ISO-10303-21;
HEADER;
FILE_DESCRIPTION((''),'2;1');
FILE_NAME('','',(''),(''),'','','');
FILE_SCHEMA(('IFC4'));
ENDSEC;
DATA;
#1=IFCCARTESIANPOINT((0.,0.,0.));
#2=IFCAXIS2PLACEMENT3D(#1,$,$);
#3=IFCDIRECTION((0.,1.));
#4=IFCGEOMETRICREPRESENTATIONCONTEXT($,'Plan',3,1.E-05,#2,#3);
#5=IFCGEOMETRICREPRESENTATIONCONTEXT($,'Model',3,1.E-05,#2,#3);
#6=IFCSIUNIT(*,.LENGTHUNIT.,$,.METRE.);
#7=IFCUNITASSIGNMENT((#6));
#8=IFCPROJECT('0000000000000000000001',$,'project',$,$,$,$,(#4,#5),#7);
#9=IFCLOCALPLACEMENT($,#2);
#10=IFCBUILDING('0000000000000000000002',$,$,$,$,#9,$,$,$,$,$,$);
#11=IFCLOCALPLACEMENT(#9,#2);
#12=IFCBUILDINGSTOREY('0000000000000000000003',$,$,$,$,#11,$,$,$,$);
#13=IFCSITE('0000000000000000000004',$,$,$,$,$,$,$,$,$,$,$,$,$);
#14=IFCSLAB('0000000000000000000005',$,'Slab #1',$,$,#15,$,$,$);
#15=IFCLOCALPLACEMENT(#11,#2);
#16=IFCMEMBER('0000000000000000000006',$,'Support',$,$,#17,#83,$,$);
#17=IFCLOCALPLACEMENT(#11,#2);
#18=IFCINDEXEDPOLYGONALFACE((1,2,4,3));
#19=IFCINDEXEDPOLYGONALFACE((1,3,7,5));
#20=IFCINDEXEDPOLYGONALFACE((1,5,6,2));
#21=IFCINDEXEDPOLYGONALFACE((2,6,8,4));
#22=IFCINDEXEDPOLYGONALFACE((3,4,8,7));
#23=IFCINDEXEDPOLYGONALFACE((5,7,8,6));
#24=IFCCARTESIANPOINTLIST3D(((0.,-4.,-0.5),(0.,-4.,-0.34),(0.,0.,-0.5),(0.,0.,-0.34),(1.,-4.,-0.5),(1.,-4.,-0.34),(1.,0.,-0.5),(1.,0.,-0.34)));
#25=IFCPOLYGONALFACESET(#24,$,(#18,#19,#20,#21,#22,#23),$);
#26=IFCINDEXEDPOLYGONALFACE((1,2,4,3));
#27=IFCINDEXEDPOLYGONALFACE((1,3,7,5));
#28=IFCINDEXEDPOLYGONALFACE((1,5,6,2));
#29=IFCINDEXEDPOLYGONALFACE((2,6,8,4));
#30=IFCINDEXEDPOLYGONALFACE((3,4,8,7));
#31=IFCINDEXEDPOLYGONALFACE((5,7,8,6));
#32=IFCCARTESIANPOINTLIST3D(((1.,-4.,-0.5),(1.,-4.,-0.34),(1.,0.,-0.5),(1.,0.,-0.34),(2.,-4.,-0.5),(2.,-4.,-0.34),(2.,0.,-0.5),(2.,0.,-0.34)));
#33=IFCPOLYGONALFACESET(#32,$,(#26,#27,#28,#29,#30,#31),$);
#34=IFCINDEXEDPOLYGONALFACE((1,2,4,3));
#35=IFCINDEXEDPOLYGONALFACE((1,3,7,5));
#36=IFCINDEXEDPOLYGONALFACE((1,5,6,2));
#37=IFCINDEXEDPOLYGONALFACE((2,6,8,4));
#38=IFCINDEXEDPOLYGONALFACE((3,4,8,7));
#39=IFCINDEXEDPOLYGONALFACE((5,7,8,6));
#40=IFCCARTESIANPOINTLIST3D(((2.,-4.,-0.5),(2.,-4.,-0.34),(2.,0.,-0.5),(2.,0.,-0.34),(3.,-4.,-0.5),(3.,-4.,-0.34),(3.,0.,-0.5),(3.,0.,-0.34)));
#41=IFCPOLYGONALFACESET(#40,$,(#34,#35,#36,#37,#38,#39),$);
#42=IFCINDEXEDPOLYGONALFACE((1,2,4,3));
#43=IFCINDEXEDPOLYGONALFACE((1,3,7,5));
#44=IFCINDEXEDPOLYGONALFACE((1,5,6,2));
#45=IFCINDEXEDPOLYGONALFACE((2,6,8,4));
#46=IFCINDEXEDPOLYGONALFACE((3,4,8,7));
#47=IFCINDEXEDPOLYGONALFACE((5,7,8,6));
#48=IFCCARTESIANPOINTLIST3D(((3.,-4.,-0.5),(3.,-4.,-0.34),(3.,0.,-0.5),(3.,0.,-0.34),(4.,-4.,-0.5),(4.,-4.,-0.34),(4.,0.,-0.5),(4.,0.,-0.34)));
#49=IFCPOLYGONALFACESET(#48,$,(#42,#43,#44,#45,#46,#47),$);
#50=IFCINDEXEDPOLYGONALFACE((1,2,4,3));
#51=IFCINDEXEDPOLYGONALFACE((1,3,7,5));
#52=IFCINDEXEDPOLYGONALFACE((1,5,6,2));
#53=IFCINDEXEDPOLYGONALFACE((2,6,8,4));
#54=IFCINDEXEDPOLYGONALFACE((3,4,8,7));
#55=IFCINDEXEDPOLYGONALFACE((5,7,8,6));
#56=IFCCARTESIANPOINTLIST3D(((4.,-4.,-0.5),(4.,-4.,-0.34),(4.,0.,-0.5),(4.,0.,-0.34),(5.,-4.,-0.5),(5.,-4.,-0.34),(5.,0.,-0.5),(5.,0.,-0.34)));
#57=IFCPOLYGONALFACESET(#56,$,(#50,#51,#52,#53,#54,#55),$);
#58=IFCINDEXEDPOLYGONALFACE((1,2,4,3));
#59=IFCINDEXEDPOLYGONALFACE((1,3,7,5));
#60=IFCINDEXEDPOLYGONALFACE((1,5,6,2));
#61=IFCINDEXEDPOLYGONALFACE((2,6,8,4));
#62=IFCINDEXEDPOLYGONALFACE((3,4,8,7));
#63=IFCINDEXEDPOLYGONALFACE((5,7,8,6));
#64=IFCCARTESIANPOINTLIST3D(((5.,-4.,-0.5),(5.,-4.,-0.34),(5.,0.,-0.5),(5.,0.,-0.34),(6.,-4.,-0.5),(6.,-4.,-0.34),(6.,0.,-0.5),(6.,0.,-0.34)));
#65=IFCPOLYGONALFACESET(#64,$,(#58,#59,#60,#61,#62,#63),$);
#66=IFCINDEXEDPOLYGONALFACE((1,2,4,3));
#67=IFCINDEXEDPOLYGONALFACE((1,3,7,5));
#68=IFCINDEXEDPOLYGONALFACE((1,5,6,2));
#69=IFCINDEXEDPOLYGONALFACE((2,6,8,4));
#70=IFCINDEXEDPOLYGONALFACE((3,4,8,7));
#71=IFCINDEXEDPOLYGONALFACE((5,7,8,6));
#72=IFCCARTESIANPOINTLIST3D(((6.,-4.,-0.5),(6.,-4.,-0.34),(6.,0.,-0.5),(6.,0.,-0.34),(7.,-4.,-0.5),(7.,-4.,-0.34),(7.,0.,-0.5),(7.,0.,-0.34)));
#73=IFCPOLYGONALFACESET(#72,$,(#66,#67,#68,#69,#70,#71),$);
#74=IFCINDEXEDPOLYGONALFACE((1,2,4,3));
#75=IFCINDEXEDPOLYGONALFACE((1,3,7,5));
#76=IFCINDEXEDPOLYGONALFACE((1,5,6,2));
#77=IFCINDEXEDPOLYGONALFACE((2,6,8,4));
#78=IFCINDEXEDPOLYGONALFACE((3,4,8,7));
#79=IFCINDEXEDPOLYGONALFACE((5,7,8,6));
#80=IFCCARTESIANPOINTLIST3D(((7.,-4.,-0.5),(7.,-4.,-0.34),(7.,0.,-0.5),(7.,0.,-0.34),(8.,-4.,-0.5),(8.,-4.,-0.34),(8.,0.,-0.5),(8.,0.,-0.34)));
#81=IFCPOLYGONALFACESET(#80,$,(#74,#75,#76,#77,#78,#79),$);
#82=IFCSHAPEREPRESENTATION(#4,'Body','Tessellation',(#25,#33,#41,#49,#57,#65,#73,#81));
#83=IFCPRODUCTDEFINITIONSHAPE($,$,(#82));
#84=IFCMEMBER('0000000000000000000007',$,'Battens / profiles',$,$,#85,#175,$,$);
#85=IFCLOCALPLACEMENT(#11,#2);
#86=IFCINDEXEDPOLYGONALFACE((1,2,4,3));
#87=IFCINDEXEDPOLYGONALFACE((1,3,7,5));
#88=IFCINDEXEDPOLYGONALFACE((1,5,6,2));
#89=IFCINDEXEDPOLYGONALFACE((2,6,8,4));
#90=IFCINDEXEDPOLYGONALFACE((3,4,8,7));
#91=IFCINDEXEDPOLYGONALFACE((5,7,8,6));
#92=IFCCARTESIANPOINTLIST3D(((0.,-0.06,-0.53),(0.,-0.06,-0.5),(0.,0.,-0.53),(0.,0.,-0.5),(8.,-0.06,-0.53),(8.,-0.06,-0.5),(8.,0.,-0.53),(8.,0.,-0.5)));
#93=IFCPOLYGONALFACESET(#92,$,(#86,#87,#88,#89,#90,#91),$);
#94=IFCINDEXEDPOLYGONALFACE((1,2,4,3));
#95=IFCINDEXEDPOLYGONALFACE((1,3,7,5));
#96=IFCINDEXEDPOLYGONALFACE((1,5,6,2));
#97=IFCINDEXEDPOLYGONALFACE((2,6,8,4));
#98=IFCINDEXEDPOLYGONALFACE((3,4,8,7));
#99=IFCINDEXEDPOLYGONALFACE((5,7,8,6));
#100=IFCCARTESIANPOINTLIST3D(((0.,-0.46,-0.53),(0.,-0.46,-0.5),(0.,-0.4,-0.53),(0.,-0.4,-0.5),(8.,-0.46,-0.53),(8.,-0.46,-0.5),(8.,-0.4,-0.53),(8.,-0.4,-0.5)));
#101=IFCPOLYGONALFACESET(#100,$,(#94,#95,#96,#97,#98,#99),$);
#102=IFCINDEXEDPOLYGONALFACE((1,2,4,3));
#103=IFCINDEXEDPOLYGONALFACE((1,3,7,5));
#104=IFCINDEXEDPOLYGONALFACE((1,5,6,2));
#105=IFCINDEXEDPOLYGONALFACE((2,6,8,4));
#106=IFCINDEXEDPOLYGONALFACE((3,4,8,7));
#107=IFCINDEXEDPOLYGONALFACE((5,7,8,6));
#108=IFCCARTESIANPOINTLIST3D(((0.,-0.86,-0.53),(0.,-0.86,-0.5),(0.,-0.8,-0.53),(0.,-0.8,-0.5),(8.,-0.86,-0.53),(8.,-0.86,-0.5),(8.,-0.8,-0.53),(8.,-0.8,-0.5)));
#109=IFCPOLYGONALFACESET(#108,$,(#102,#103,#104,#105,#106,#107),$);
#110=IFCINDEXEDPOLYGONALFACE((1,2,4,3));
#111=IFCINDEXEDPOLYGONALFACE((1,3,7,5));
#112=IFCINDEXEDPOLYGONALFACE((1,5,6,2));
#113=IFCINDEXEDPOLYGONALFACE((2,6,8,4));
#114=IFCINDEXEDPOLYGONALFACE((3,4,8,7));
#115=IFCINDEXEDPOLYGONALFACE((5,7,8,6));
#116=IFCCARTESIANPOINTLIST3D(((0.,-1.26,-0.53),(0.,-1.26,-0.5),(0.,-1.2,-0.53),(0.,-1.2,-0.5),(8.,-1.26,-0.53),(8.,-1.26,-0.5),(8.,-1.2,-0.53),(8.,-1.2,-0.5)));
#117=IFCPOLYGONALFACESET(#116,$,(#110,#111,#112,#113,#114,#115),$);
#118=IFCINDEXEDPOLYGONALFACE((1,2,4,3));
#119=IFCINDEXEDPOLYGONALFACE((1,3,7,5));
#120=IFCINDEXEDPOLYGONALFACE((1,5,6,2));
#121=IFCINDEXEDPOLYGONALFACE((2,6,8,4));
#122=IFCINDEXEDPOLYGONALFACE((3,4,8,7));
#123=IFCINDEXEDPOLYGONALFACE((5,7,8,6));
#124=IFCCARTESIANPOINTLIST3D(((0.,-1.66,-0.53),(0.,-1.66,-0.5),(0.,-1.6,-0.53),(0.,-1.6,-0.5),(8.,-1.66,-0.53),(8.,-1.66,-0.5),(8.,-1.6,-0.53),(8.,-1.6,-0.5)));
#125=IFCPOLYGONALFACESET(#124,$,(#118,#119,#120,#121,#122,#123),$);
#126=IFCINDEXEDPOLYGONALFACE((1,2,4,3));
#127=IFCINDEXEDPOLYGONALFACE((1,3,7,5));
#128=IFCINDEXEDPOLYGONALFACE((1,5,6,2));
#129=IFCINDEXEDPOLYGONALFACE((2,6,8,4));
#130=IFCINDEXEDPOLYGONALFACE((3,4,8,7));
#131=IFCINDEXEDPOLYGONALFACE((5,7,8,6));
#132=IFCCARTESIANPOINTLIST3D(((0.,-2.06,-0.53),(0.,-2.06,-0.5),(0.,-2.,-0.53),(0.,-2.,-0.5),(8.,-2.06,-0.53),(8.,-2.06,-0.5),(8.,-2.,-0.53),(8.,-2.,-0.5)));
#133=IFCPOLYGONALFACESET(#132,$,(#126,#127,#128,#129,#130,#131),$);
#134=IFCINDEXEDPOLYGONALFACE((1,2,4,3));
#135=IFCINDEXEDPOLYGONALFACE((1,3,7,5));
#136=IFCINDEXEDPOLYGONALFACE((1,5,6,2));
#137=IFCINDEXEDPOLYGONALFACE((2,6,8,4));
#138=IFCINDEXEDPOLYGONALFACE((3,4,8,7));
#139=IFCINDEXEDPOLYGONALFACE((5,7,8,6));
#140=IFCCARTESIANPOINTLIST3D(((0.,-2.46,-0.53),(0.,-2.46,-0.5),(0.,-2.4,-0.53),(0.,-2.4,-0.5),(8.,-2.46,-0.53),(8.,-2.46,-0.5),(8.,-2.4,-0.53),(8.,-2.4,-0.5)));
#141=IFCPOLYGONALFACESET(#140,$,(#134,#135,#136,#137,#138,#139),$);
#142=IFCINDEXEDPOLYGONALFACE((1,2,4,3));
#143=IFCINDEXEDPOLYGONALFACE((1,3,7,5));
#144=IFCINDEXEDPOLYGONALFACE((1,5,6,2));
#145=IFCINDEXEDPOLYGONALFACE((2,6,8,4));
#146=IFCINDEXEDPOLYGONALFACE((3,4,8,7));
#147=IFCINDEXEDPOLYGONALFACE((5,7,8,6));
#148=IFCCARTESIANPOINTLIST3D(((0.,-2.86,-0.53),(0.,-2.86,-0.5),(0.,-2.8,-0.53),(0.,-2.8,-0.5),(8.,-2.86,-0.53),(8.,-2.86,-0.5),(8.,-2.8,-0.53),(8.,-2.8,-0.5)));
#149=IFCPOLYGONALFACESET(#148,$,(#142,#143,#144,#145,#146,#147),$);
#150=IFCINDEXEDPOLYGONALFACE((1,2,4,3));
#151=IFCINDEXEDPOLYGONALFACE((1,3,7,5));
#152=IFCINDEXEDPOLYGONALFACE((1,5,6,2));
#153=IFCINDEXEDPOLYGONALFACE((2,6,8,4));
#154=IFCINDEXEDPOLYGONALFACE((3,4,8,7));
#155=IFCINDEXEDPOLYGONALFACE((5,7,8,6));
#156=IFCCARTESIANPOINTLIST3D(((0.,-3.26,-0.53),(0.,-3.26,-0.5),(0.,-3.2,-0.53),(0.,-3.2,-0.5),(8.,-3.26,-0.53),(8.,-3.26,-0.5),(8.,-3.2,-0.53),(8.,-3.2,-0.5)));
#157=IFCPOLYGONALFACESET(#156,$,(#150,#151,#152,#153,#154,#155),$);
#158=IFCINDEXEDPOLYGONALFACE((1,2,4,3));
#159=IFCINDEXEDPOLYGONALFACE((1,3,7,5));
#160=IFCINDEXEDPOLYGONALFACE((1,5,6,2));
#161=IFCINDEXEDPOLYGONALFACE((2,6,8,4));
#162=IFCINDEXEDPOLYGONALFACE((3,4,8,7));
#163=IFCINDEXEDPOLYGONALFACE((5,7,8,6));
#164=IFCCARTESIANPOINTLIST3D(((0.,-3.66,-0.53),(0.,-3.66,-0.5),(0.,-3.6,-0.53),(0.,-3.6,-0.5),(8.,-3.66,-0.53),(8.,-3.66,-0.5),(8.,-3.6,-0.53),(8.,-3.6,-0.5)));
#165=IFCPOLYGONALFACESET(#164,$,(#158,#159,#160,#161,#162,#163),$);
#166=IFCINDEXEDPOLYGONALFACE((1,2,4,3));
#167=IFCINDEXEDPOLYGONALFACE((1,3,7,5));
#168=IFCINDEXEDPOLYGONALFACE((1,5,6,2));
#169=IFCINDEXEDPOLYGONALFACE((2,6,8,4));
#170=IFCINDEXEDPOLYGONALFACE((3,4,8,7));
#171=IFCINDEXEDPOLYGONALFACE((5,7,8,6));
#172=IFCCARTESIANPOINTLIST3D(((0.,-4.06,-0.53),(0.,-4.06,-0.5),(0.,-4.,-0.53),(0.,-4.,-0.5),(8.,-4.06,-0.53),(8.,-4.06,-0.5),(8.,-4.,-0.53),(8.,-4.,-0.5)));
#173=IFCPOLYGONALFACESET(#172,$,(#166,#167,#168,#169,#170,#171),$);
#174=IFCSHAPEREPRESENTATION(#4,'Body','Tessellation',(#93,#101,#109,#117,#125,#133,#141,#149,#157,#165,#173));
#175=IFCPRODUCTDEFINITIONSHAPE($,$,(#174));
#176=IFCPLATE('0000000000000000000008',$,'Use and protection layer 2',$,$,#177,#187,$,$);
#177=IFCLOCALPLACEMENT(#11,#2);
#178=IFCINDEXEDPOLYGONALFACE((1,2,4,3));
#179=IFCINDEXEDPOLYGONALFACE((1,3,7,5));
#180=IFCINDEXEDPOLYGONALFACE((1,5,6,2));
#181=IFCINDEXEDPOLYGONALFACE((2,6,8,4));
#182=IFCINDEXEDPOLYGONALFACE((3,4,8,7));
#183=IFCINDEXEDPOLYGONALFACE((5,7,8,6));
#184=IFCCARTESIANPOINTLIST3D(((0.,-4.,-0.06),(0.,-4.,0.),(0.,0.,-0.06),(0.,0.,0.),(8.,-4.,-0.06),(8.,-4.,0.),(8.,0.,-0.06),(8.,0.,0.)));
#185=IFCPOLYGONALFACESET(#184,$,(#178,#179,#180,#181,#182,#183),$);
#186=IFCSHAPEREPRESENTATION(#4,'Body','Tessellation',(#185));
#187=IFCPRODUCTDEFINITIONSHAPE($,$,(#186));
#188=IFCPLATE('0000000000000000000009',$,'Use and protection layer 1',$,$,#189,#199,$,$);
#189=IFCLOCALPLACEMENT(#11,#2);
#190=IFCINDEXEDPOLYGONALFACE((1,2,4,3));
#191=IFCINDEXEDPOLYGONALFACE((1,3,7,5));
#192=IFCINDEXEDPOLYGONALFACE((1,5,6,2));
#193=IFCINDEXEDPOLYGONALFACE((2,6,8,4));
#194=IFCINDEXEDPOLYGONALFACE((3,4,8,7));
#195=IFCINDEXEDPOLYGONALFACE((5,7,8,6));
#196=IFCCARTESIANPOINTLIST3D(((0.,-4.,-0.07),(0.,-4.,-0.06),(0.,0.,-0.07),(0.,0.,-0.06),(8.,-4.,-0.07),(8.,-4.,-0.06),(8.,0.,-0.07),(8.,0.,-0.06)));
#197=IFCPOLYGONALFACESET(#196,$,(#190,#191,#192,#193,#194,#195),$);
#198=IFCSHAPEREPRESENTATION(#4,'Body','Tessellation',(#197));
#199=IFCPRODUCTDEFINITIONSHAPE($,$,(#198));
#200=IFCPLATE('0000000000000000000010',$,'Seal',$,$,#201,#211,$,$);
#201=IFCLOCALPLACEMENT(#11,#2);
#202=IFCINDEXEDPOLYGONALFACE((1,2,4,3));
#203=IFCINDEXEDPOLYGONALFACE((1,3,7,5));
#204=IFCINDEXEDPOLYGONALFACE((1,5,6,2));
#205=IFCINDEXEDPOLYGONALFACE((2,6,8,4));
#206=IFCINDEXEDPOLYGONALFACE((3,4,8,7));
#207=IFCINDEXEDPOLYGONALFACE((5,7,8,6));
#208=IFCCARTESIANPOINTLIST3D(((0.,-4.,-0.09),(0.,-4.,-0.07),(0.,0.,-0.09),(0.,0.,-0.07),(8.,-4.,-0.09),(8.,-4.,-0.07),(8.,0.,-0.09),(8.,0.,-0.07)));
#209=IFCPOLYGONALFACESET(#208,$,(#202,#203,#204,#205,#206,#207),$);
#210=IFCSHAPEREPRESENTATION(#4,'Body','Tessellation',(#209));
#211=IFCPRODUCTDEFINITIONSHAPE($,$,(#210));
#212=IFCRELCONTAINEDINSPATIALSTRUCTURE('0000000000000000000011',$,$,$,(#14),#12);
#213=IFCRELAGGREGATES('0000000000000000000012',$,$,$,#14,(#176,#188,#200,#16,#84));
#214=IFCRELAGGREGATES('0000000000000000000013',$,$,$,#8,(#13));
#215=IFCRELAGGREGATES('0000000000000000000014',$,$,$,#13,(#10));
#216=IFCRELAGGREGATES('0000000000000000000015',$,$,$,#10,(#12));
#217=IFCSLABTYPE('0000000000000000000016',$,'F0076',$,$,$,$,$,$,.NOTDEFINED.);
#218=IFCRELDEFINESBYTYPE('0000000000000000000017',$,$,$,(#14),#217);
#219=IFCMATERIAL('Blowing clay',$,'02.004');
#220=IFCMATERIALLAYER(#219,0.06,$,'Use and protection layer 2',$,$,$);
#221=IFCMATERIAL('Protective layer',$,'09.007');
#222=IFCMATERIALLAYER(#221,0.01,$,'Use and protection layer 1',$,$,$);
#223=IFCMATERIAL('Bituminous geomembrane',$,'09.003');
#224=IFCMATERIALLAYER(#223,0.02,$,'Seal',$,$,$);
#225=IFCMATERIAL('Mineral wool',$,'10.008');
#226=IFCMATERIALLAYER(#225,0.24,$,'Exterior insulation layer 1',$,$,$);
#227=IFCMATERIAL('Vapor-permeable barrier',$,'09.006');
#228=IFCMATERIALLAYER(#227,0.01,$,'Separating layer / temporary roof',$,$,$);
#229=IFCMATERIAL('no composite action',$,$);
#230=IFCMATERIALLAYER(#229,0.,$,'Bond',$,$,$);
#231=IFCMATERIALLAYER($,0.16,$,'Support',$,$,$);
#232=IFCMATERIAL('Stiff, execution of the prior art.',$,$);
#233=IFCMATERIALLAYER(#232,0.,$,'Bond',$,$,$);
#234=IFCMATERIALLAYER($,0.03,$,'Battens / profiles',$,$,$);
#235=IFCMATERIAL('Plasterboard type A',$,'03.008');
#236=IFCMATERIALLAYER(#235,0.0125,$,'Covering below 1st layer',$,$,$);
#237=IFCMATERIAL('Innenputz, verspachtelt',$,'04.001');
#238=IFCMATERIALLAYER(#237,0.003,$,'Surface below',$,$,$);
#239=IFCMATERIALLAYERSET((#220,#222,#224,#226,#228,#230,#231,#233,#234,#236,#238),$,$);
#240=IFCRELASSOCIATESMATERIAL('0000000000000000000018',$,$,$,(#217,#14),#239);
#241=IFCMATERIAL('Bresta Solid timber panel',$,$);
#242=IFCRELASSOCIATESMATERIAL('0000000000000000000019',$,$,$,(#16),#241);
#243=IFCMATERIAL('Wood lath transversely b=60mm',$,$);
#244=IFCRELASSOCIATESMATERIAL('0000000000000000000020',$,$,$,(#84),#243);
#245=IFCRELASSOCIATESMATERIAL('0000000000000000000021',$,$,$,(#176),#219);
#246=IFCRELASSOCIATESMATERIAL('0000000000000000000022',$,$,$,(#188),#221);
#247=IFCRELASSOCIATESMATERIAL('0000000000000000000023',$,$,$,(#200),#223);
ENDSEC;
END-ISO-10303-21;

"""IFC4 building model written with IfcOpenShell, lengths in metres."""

from ifc_helpers import new_model, si_unit, direction, frame, frame_2d, origin, origin_with_axes, place, context, project, spatial, rectangle, extrude, material, layer, layer_set, type_object, element, aggregate, save


model = new_model("IFC4")

# Units and contexts
plan_context = context("Plan", 3, precision=1e-05, world=origin(), true_north=direction((0.0, 1.0)))
model_context = context("Model", 3, precision=1e-05, world=origin(), true_north=direction((0.0, 1.0)))
ifc_project = project(units=[si_unit("LENGTHUNIT", "METRE")], contexts=[plan_context, model_context])

# Site, building, storey
site = spatial("IfcSite", under=ifc_project)
building_placement = place(None, origin())
building = spatial("IfcBuilding", under=site, at=building_placement)
storey_placement = place(building_placement, origin())
storey = spatial("IfcBuildingStorey", under=building, at=storey_placement)

# Slab, members, plates
ifc_material_1 = material(Name="Blowing clay", Category="02.004")
ifc_layer_1 = layer(ifc_material_1, 0.06, Name="Use and protection layer 2")
ifc_material_2 = material(Name="Protective layer", Category="09.007")
ifc_layer_2 = layer(ifc_material_2, 0.01, Name="Use and protection layer 1")
ifc_material_3 = material(Name="Bituminous geomembrane", Category="09.003")
ifc_layer_3 = layer(ifc_material_3, 0.02, Name="Seal")
ifc_material_4 = material(Name="Mineral wool", Category="10.008")
ifc_layer_4 = layer(ifc_material_4, 0.24, Name="Exterior insulation layer 1")
ifc_material_5 = material(Name="Vapor-permeable barrier", Category="09.006")
ifc_layer_5 = layer(ifc_material_5, 0.01, Name="Separating layer / temporary roof")
ifc_material_6 = material(Name="no composite action")
ifc_layer_6 = layer(ifc_material_6, 0.0, Name="Bond")
ifc_layer_7 = layer(None, 0.16, Name="Support")
ifc_material_7 = material(Name="Stiff, execution of the prior art.")
ifc_layer_8 = layer(ifc_material_7, 0.0, Name="Bond")
ifc_layer_9 = layer(None, 0.03, Name="Battens / profiles")
ifc_material_8 = material(Name="Plasterboard type A", Category="03.008")
ifc_layer_10 = layer(ifc_material_8, 0.0125, Name="Covering below 1st layer")
ifc_material_9 = material(Name="Innenputz, verspachtelt", Category="04.001")
ifc_layer_11 = layer(ifc_material_9, 0.003, Name="Surface below")
ifc_layer_set = layer_set([ifc_layer_1, ifc_layer_2, ifc_layer_3, ifc_layer_4, ifc_layer_5, ifc_layer_6, ifc_layer_7, ifc_layer_8, ifc_layer_9, ifc_layer_10, ifc_layer_11])
slab_type = type_object("IfcSlabType", Name="F0076", PredefinedType="NOTDEFINED", material=ifc_layer_set)
slab_placement = place(None, frame((0.0, 0.0, 0.0), z_axis=(0.0, 0.0, -1.0), x_axis=(1.0, 0.0, 0.0)))
slab = element("IfcSlab", 1, at=slab_placement, inside=storey, type_object=slab_type, material=ifc_layer_set, Name="Slab #1")
ifc_material_10 = material(Name="Bresta Solid timber panel")
member_1_placement = place(slab_placement, origin())
member_1 = element("IfcMember", 2, at=member_1_placement, material=ifc_material_10, Name="Support", context=plan_context, shape_type="SweptSolid", body=[
    extrude(rectangle(XDim=1.0, YDim=0.16, at=frame_2d((0.5, 0.08), x_axis=(1.0, 0.0))), frame((0.0, 4.0, 0.34), z_axis=(0.0, -1.0, 0.0), x_axis=(1.0, 0.0, 0.0)), (0.0, 0.0, 1.0), 4.0),
    extrude(rectangle(XDim=1.0, YDim=0.16, at=frame_2d((0.5, 0.08), x_axis=(1.0, 0.0))), frame((1.0, 4.0, 0.34), z_axis=(0.0, -1.0, 0.0), x_axis=(1.0, 0.0, 0.0)), (0.0, 0.0, 1.0), 4.0),
    extrude(rectangle(XDim=1.0, YDim=0.16, at=frame_2d((0.5, 0.08), x_axis=(1.0, 0.0))), frame((2.0, 4.0, 0.34), z_axis=(0.0, -1.0, 0.0), x_axis=(1.0, 0.0, 0.0)), (0.0, 0.0, 1.0), 4.0),
    extrude(rectangle(XDim=1.0, YDim=0.16, at=frame_2d((0.5, 0.08), x_axis=(1.0, 0.0))), frame((3.0, 4.0, 0.34), z_axis=(0.0, -1.0, 0.0), x_axis=(1.0, 0.0, 0.0)), (0.0, 0.0, 1.0), 4.0),
    extrude(rectangle(XDim=1.0, YDim=0.16, at=frame_2d((0.5, 0.08), x_axis=(1.0, 0.0))), frame((4.0, 4.0, 0.34), z_axis=(0.0, -1.0, 0.0), x_axis=(1.0, 0.0, 0.0)), (0.0, 0.0, 1.0), 4.0),
    extrude(rectangle(XDim=1.0, YDim=0.16, at=frame_2d((0.5, 0.08), x_axis=(1.0, 0.0))), frame((5.0, 4.0, 0.34), z_axis=(0.0, -1.0, 0.0), x_axis=(1.0, 0.0, 0.0)), (0.0, 0.0, 1.0), 4.0),
    extrude(rectangle(XDim=1.0, YDim=0.16, at=frame_2d((0.5, 0.08), x_axis=(1.0, 0.0))), frame((6.0, 4.0, 0.34), z_axis=(0.0, -1.0, 0.0), x_axis=(1.0, 0.0, 0.0)), (0.0, 0.0, 1.0), 4.0),
    extrude(rectangle(XDim=1.0, YDim=0.16, at=frame_2d((0.5, 0.08), x_axis=(1.0, 0.0))), frame((7.0, 4.0, 0.34), z_axis=(0.0, -1.0, 0.0), x_axis=(1.0, 0.0, 0.0)), (0.0, 0.0, 1.0), 4.0),
])
ifc_material_11 = material(Name="Wood lath transversely b=60mm")
member_2_placement = place(slab_placement, origin())
member_2 = element("IfcMember", 3, at=member_2_placement, material=ifc_material_11, Name="Battens / profiles", context=plan_context, shape_type="SweptSolid", body=[
    extrude(rectangle(XDim=0.06, YDim=0.03, at=frame_2d((0.03, 0.015), x_axis=(1.0, 0.0))), frame((0.0, 0.0, 0.5), z_axis=(1.0, 0.0, 0.0), x_axis=(0.0, 1.0, 0.0)), (0.0, 0.0, 1.0), 8.0),
    extrude(rectangle(XDim=0.06, YDim=0.03, at=frame_2d((0.03, 0.015), x_axis=(1.0, 0.0))), frame((0.0, 0.4, 0.5), z_axis=(1.0, 0.0, 0.0), x_axis=(0.0, 1.0, 0.0)), (0.0, 0.0, 1.0), 8.0),
    extrude(rectangle(XDim=0.06, YDim=0.03, at=frame_2d((0.03, 0.015), x_axis=(1.0, 0.0))), frame((0.0, 0.8, 0.5), z_axis=(1.0, 0.0, 0.0), x_axis=(0.0, 1.0, 0.0)), (0.0, 0.0, 1.0), 8.0),
    extrude(rectangle(XDim=0.06, YDim=0.03, at=frame_2d((0.03, 0.015), x_axis=(1.0, 0.0))), frame((0.0, 1.2, 0.5), z_axis=(1.0, 0.0, 0.0), x_axis=(0.0, 1.0, 0.0)), (0.0, 0.0, 1.0), 8.0),
    extrude(rectangle(XDim=0.06, YDim=0.03, at=frame_2d((0.03, 0.015), x_axis=(1.0, 0.0))), frame((0.0, 1.6, 0.5), z_axis=(1.0, 0.0, 0.0), x_axis=(0.0, 1.0, 0.0)), (0.0, 0.0, 1.0), 8.0),
    extrude(rectangle(XDim=0.06, YDim=0.03, at=frame_2d((0.03, 0.015), x_axis=(1.0, 0.0))), frame((0.0, 2.0, 0.5), z_axis=(1.0, 0.0, 0.0), x_axis=(0.0, 1.0, 0.0)), (0.0, 0.0, 1.0), 8.0),
    extrude(rectangle(XDim=0.06, YDim=0.03, at=frame_2d((0.03, 0.015), x_axis=(1.0, 0.0))), frame((0.0, 2.4, 0.5), z_axis=(1.0, 0.0, 0.0), x_axis=(0.0, 1.0, 0.0)), (0.0, 0.0, 1.0), 8.0),
    extrude(rectangle(XDim=0.06, YDim=0.03, at=frame_2d((0.03, 0.015), x_axis=(1.0, 0.0))), frame((0.0, 2.8, 0.5), z_axis=(1.0, 0.0, 0.0), x_axis=(0.0, 1.0, 0.0)), (0.0, 0.0, 1.0), 8.0),
    extrude(rectangle(XDim=0.06, YDim=0.03, at=frame_2d((0.03, 0.015), x_axis=(1.0, 0.0))), frame((0.0, 3.2, 0.5), z_axis=(1.0, 0.0, 0.0), x_axis=(0.0, 1.0, 0.0)), (0.0, 0.0, 1.0), 8.0),
    extrude(rectangle(XDim=0.06, YDim=0.03, at=frame_2d((0.03, 0.015), x_axis=(1.0, 0.0))), frame((0.0, 3.6, 0.5), z_axis=(1.0, 0.0, 0.0), x_axis=(0.0, 1.0, 0.0)), (0.0, 0.0, 1.0), 8.0),
    extrude(rectangle(XDim=0.06, YDim=0.03, at=frame_2d((0.03, 0.015), x_axis=(1.0, 0.0))), frame((0.0, 4.0, 0.5), z_axis=(1.0, 0.0, 0.0), x_axis=(0.0, 1.0, 0.0)), (0.0, 0.0, 1.0), 8.0),
])
plate_1_placement = place(slab_placement, origin())
plate_1 = element("IfcPlate", 4, at=plate_1_placement, material=ifc_material_1, Name="Use and protection layer 2", context=plan_context, shape_type="SweptSolid", body=[
    extrude(rectangle(XDim=8.0, YDim=4.0, at=frame_2d((4.0, 2.0), x_axis=(1.0, 0.0))), origin_with_axes(), (0.0, 0.0, 1.0), 0.06),
])
plate_2_placement = place(slab_placement, origin())
plate_2 = element("IfcPlate", 5, at=plate_2_placement, material=ifc_material_2, Name="Use and protection layer 1", context=plan_context, shape_type="SweptSolid", body=[
    extrude(rectangle(XDim=8.0, YDim=4.0, at=frame_2d((4.0, 2.0), x_axis=(1.0, 0.0))), frame((0.0, 0.0, 0.06), z_axis=(0.0, 0.0, 1.0), x_axis=(1.0, 0.0, 0.0)), (0.0, 0.0, 1.0), 0.01),
])
plate_3_placement = place(slab_placement, origin())
plate_3 = element("IfcPlate", 6, at=plate_3_placement, material=ifc_material_3, Name="Seal", context=plan_context, shape_type="SweptSolid", body=[
    extrude(rectangle(XDim=8.0, YDim=4.0, at=frame_2d((4.0, 2.0), x_axis=(1.0, 0.0))), frame((0.0, 0.0, 0.07), z_axis=(0.0, 0.0, 1.0), x_axis=(1.0, 0.0, 0.0)), (0.0, 0.0, 1.0), 0.02),
])
aggregate(slab, [plate_1, plate_2, plate_3, member_1, member_2])

save(model, "model.ifc")
